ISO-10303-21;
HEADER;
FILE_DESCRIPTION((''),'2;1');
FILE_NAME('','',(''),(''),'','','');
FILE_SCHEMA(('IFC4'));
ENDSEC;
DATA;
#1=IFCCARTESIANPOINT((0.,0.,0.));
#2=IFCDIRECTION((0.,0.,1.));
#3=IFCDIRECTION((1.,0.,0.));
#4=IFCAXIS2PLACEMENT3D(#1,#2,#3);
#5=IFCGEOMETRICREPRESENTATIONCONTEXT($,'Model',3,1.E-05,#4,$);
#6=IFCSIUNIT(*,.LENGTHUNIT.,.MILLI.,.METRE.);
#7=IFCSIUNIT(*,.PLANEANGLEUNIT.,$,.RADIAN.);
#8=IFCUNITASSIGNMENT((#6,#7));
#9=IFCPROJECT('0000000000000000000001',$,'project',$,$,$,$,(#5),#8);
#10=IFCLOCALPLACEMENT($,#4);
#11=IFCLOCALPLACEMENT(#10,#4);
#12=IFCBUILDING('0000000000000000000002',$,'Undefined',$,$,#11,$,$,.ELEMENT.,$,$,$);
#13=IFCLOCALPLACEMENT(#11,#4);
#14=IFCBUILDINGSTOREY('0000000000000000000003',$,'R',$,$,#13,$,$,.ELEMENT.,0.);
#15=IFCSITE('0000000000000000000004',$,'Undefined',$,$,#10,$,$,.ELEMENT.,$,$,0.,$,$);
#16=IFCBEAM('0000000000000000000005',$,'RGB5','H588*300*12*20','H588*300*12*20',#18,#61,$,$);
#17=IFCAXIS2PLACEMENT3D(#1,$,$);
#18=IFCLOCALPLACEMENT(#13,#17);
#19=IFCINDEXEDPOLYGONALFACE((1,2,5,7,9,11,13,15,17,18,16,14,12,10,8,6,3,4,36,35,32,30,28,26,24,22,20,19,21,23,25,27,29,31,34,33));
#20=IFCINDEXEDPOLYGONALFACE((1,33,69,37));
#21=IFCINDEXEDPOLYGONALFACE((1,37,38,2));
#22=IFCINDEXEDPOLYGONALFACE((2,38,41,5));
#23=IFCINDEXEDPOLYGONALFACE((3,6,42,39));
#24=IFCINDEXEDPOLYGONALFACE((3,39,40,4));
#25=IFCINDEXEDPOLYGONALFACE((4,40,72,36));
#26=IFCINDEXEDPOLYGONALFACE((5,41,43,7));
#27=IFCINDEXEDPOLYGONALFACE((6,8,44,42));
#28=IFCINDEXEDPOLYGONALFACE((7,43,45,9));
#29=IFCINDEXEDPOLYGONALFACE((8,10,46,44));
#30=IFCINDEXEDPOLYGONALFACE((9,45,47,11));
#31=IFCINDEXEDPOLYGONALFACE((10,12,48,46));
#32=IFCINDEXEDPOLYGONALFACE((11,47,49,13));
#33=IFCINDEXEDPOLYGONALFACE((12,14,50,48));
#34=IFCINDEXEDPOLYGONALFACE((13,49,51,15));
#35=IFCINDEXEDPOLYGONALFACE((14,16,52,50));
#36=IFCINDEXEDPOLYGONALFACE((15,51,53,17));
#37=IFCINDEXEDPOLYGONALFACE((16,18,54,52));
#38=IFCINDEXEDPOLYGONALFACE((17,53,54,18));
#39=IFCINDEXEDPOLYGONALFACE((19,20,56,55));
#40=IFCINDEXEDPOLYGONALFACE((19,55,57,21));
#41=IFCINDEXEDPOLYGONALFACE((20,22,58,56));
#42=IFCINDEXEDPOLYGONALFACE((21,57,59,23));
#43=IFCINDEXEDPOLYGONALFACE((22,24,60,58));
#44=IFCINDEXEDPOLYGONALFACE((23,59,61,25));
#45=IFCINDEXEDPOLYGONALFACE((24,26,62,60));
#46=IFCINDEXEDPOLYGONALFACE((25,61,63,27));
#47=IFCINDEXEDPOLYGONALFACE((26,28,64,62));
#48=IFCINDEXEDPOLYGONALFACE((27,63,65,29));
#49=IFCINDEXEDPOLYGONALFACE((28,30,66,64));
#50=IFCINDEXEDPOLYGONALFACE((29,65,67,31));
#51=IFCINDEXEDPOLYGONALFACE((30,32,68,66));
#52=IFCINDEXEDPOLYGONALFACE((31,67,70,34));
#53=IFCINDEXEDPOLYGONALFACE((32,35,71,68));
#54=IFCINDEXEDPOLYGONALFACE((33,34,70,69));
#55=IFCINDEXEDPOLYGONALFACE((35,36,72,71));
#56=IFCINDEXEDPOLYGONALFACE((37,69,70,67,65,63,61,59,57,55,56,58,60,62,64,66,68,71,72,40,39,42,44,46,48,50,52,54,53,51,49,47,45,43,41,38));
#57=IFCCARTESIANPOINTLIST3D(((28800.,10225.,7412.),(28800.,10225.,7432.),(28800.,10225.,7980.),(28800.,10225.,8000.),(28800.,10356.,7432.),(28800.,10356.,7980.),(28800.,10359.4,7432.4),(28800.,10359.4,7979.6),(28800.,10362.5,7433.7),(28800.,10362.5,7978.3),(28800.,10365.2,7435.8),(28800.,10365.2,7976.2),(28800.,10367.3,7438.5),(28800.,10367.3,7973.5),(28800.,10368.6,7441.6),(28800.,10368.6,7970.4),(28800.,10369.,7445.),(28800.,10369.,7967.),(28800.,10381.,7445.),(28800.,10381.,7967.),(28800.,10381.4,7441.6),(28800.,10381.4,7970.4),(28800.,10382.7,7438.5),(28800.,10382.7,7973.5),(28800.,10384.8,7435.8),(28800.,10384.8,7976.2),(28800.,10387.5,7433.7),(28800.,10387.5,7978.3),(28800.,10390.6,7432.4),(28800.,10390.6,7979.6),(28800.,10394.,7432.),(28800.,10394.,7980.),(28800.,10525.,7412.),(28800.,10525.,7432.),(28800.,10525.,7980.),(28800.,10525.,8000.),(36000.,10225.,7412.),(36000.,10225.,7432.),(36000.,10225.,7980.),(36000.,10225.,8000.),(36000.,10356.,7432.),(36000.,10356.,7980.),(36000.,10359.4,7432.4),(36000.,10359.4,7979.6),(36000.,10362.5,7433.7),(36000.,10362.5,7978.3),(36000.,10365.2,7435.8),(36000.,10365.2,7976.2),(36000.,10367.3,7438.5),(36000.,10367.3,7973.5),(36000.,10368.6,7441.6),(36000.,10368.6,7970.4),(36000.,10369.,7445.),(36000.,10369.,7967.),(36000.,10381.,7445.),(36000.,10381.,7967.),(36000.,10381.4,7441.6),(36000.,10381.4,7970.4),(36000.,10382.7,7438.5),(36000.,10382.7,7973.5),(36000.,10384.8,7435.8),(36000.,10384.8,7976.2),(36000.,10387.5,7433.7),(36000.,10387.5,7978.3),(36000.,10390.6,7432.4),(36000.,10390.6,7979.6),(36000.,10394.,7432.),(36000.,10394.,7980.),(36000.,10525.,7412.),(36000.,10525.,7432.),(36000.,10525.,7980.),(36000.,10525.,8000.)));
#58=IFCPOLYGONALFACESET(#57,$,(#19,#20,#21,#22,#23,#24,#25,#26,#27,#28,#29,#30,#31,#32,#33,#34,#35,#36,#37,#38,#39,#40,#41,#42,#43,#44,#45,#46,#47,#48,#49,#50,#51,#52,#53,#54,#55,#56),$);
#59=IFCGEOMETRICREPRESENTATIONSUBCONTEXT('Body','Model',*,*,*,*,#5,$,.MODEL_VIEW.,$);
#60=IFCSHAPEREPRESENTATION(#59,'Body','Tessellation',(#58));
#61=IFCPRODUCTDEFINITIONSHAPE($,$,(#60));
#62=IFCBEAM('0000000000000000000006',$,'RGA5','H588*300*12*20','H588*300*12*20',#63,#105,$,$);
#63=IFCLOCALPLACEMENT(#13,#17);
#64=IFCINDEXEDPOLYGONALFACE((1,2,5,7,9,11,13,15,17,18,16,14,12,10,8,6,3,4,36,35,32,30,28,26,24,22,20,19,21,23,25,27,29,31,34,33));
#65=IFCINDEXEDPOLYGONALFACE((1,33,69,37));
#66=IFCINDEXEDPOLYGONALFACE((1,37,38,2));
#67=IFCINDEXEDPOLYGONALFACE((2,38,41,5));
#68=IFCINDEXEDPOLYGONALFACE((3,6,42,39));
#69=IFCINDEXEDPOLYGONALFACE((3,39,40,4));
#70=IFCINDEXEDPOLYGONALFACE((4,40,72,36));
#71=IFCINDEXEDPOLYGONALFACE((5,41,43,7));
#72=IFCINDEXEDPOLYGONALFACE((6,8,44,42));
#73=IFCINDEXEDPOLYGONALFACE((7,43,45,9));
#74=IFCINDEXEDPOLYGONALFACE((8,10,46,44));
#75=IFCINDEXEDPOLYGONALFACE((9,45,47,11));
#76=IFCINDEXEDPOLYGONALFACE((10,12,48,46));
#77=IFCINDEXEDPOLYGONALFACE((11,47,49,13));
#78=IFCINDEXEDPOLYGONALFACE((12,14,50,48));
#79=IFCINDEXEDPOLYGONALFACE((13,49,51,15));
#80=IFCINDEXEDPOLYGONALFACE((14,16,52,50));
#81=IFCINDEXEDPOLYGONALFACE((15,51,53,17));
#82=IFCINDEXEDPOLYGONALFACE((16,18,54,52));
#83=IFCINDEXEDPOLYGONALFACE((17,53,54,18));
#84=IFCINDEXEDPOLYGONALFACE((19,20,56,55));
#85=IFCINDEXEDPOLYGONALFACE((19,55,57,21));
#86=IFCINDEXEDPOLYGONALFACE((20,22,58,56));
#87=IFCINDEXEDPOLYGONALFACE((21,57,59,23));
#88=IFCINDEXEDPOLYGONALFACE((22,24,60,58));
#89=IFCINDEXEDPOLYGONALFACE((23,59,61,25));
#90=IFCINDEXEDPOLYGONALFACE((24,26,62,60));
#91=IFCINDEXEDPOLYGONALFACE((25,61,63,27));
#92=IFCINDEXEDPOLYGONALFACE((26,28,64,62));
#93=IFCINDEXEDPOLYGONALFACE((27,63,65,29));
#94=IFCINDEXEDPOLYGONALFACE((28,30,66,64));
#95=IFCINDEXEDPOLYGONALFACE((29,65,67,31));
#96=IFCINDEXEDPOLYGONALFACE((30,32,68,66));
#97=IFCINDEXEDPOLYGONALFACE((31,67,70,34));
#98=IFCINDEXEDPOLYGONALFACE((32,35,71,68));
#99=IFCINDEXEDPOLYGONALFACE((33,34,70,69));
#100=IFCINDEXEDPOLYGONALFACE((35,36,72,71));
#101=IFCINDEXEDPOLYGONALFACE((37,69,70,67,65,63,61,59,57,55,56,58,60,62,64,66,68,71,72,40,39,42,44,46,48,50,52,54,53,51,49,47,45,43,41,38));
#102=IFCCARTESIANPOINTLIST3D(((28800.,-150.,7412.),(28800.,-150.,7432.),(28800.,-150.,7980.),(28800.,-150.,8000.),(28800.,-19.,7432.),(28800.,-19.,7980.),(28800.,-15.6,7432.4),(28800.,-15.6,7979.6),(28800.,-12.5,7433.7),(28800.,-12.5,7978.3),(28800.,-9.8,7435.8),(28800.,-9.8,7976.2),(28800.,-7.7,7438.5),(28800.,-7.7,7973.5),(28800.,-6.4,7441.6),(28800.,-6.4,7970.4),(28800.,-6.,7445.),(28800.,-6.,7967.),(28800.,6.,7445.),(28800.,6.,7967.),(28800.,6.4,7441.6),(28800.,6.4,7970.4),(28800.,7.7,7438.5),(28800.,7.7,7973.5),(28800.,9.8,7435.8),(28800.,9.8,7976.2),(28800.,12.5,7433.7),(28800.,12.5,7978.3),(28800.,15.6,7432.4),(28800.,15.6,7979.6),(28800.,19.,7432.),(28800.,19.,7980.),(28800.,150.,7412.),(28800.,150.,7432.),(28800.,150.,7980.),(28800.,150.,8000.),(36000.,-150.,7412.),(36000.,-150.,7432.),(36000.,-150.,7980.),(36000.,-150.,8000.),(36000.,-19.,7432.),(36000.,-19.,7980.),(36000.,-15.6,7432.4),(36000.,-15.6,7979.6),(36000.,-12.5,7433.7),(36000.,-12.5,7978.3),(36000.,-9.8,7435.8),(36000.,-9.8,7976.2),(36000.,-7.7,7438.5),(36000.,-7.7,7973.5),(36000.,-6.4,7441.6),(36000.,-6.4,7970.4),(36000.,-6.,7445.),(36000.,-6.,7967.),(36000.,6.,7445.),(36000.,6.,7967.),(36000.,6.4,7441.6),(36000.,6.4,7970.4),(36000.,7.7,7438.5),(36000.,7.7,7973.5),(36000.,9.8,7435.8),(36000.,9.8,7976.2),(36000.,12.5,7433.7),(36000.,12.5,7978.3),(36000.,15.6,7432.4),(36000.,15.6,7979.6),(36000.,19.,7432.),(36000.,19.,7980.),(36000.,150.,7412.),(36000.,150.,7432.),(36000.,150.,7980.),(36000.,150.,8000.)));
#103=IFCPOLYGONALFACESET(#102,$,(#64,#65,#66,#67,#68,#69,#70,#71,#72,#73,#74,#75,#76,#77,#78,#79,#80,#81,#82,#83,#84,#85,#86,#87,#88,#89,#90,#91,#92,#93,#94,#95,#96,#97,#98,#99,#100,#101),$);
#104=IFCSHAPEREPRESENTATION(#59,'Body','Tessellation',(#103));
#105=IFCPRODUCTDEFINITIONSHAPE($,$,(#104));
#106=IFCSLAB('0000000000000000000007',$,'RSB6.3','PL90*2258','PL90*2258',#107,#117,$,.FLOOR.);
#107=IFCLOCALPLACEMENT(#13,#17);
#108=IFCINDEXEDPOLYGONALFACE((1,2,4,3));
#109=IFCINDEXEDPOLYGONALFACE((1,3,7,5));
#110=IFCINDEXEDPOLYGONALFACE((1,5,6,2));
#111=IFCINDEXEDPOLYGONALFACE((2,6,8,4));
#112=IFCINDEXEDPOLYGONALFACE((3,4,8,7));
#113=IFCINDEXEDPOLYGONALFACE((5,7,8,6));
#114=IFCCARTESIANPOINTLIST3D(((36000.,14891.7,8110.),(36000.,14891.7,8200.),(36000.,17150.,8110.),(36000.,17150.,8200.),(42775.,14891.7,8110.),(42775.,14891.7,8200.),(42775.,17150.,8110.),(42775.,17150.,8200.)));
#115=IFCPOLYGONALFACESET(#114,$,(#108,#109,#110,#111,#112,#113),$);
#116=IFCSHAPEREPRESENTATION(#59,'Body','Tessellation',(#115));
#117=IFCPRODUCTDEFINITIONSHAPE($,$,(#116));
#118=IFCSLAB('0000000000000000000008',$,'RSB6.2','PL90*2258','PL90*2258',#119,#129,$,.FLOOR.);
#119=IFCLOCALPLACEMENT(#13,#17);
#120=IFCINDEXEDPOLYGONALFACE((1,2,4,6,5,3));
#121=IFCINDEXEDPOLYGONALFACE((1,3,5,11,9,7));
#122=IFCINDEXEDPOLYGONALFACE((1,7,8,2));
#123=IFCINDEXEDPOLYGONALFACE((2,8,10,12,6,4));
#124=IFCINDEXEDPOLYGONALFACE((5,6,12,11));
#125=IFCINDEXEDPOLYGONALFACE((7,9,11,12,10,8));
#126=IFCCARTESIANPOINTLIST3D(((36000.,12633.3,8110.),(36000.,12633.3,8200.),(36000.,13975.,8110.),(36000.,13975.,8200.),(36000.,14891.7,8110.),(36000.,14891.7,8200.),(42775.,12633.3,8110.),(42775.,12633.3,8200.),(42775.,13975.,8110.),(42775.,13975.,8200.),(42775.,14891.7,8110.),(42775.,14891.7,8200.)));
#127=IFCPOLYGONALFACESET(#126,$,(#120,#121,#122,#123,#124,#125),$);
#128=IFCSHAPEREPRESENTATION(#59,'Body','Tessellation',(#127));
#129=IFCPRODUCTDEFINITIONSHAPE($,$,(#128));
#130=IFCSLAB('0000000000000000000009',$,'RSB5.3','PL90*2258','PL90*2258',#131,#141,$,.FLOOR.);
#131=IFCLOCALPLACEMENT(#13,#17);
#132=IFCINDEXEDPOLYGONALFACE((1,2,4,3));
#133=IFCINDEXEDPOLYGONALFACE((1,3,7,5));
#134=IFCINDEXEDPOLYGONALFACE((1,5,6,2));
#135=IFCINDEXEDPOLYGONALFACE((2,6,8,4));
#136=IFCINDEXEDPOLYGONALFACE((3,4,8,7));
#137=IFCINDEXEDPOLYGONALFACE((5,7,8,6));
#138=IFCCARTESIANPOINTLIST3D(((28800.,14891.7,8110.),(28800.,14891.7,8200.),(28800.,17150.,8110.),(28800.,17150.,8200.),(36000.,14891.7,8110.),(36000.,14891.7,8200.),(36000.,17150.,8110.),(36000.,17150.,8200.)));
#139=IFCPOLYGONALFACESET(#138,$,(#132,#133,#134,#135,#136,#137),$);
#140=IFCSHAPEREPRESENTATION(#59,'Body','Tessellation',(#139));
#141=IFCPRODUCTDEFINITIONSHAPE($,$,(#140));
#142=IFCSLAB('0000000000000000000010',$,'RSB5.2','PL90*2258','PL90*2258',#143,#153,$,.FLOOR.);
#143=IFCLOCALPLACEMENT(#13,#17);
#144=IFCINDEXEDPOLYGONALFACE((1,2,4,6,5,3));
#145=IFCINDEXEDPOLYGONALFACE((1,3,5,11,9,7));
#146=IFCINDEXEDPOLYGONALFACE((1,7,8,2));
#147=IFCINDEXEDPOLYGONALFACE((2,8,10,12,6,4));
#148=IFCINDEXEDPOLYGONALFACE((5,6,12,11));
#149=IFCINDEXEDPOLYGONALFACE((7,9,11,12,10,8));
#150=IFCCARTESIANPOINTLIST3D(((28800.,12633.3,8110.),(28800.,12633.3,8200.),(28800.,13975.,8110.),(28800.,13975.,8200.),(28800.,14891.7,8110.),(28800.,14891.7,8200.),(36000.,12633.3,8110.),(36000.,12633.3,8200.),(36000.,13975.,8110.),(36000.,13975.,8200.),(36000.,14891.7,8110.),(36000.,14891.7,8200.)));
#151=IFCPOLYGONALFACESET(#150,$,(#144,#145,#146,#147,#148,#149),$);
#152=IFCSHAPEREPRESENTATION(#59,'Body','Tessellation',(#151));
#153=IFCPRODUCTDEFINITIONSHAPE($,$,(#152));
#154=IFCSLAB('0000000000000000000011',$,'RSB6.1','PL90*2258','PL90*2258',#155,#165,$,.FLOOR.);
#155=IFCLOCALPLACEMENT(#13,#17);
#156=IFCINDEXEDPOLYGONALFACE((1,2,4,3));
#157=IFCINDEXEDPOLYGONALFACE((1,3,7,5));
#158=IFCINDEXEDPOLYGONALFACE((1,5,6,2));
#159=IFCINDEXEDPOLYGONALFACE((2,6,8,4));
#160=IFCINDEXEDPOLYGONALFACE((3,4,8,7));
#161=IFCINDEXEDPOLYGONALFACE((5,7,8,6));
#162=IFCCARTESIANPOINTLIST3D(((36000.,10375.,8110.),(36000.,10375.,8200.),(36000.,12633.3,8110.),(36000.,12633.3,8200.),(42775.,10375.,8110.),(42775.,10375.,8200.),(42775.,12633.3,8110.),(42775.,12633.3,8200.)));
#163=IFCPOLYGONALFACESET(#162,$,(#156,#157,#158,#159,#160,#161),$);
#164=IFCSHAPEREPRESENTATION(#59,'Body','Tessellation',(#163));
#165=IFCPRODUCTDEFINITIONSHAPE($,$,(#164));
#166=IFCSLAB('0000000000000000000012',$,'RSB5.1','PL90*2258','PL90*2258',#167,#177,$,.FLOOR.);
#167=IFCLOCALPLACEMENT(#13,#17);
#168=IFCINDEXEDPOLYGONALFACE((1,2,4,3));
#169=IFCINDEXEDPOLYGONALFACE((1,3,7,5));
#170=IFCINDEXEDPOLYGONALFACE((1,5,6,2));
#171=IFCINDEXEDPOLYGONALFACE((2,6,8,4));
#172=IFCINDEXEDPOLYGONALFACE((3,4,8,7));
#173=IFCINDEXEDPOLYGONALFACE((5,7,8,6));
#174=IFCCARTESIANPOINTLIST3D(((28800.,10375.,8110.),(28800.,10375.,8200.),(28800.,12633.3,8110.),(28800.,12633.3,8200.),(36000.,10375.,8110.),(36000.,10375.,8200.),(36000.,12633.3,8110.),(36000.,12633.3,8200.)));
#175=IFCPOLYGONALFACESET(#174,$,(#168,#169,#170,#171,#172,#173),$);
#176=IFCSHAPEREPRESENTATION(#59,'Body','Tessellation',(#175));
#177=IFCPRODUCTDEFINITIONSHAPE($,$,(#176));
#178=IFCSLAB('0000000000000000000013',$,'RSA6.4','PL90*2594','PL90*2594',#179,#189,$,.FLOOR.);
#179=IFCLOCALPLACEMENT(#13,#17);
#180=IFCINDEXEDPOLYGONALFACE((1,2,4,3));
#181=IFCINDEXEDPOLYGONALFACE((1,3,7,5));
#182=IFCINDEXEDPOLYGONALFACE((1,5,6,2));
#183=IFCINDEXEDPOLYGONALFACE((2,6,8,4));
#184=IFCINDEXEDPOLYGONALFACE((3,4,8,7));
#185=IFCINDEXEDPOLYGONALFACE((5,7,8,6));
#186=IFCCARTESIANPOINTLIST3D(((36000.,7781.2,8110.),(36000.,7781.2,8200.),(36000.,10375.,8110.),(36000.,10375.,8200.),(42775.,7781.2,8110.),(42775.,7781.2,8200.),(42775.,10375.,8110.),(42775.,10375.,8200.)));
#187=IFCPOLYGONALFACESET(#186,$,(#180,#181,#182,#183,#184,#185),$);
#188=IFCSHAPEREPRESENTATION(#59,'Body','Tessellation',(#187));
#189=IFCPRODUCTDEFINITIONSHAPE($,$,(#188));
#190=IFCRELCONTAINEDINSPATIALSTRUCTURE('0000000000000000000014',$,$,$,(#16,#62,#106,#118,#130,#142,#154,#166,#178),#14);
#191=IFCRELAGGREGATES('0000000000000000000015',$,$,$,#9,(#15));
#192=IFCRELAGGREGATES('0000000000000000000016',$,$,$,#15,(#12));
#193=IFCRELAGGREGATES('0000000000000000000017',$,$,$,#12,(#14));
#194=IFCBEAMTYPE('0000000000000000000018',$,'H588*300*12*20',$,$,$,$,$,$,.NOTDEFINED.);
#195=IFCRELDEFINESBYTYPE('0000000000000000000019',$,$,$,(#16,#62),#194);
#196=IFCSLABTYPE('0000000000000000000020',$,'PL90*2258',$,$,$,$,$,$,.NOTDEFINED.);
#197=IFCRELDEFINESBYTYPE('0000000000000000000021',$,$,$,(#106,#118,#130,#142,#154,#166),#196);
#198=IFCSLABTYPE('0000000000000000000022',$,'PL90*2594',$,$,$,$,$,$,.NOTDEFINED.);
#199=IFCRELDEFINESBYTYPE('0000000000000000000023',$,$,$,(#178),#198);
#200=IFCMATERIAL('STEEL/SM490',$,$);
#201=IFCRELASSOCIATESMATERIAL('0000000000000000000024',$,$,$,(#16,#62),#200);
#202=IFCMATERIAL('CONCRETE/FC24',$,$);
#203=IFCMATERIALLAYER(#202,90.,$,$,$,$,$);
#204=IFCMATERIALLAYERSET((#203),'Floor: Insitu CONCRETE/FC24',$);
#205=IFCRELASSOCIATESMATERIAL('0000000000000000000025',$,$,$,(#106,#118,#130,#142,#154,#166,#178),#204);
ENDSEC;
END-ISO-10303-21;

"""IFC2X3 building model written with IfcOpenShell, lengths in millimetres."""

from ifc_helpers import new_model, si_unit, frame, origin_with_axes, origin_2d_with_axis, place, context, subcontext, project, spatial, polyline, i_section, outline, extrude, material, layer, layer_set, layer_usage, type_object, element, save


model = new_model("IFC2X3")

# Units and contexts
model_context = context("Model", 3, precision=1e-05, world=origin_with_axes())
body_context = subcontext(model_context, "Body", "Model", "MODEL_VIEW")
ifc_project = project(units=[si_unit("LENGTHUNIT", "METRE", prefix="MILLI"), si_unit("PLANEANGLEUNIT", "RADIAN")], contexts=[model_context])

# Site, building, storey
site_placement = place(None, origin_with_axes())
site = spatial("IfcSite", under=ifc_project, at=site_placement, Name="Undefined", CompositionType="ELEMENT", RefElevation=0.0)
building_placement = place(site_placement, origin_with_axes())
building = spatial("IfcBuilding", under=site, at=building_placement, Name="Undefined", CompositionType="ELEMENT")
storey_placement = place(building_placement, origin_with_axes())
storey = spatial("IfcBuildingStorey", under=building, at=storey_placement, Name="R", CompositionType="ELEMENT", Elevation=0.0)

# Beams
ifc_material_1 = material(Name="STEEL/SM490")
beam_type_1 = type_object("IfcBeamType", Name="H588*300*12*20", PredefinedType="NOTDEFINED")
for number, where, z_axis, x_axis, name in (
    (1, (28800.0, 10375.0, 7706.0), (0.0, 0.0, 1.0), (1.0, 0.0, 0.0), "RGB5"),
    (2, (28800.0, 0.0, 7706.0), (0.0, 0.0, 1.0), (1.0, 0.0, 0.0), "RGA5"),
):
    element("IfcBeam", number, at=place(storey_placement, frame(where, z_axis=z_axis, x_axis=x_axis)), inside=storey, type_object=beam_type_1, material=ifc_material_1, Name=name, Description="H588*300*12*20", ObjectType="H588*300*12*20", context=body_context, shape_type="SweptSolid", body=[
        extrude(i_section(OverallWidth=300.0, OverallDepth=588.0, WebThickness=12.0, FlangeThickness=20.0, FilletRadius=13.0, at=origin_2d_with_axis()), frame((7200.0, 0.0, 0.0), z_axis=(-1.0, 0.0, 0.0), x_axis=(0.0, -1.0, 0.0)), (0.0, 0.0, 1.0), 7200.0),
    ])

# Slabs
ifc_material_2 = material(Name="CONCRETE/FC24")
ifc_layer = layer(ifc_material_2, 90.0)
ifc_layer_set = layer_set([ifc_layer], Name="Floor: Insitu CONCRETE/FC24")
ifc_layer_usage_1 = layer_usage(ifc_layer_set, "AXIS3", "POSITIVE", -45.0)
slab_type_1 = type_object("IfcSlabType", Name="PL90*2258", PredefinedType="NOTDEFINED")
slab_1_placement = place(storey_placement, frame((36000.0, 14891.7, 8155.0), z_axis=(0.0, 0.0, 1.0), x_axis=(1.0, 0.0, 0.0)))
element("IfcSlab", 3, at=slab_1_placement, inside=storey, type_object=slab_type_1, material=ifc_layer_usage_1, Name="RSB6.3", Description="PL90*2258", ObjectType="PL90*2258", PredefinedType="FLOOR", context=body_context, shape_type="SweptSolid", body=[
    extrude(outline(polyline([(0.0, 0.0), (6775.0, 0.0), (6775.0, 2258.3), (0.0, 2258.3), (0.0, 0.0)])), frame((0.0, 0.0, -45.0), z_axis=(0.0, 0.0, 1.0), x_axis=(1.0, 0.0, 0.0)), (0.0, 0.0, 1.0), 90.0),
])
ifc_layer_usage_2 = layer_usage(ifc_layer_set, "AXIS3", "POSITIVE", -45.0)
slab_2_placement = place(storey_placement, frame((36000.0, 12633.3, 8155.0), z_axis=(0.0, 0.0, 1.0), x_axis=(1.0, 0.0, 0.0)))
element("IfcSlab", 4, at=slab_2_placement, inside=storey, type_object=slab_type_1, material=ifc_layer_usage_2, Name="RSB6.2", Description="PL90*2258", ObjectType="PL90*2258", PredefinedType="FLOOR", context=body_context, shape_type="SweptSolid", body=[
    extrude(outline(polyline([(0.0, 0.0), (6775.0, 0.0), (6775.0, 1341.7), (6775.0, 2258.4), (0.0, 2258.4), (0.0, 1341.7), (0.0, 0.0)])), frame((0.0, 0.0, -45.0), z_axis=(0.0, 0.0, 1.0), x_axis=(1.0, 0.0, 0.0)), (0.0, 0.0, 1.0), 90.0),
])
ifc_layer_usage_3 = layer_usage(ifc_layer_set, "AXIS3", "POSITIVE", -45.0)
slab_3_placement = place(storey_placement, frame((28800.0, 14891.7, 8155.0), z_axis=(0.0, 0.0, 1.0), x_axis=(1.0, 0.0, 0.0)))
element("IfcSlab", 5, at=slab_3_placement, inside=storey, type_object=slab_type_1, material=ifc_layer_usage_3, Name="RSB5.3", Description="PL90*2258", ObjectType="PL90*2258", PredefinedType="FLOOR", context=body_context, shape_type="SweptSolid", body=[
    extrude(outline(polyline([(0.0, 0.0), (7200.0, 0.0), (7200.0, 2258.3), (0.0, 2258.3), (0.0, 0.0)])), frame((0.0, 0.0, -45.0), z_axis=(0.0, 0.0, 1.0), x_axis=(1.0, 0.0, 0.0)), (0.0, 0.0, 1.0), 90.0),
])
ifc_layer_usage_4 = layer_usage(ifc_layer_set, "AXIS3", "POSITIVE", -45.0)
slab_4_placement = place(storey_placement, frame((28800.0, 12633.3, 8155.0), z_axis=(0.0, 0.0, 1.0), x_axis=(1.0, 0.0, 0.0)))
element("IfcSlab", 6, at=slab_4_placement, inside=storey, type_object=slab_type_1, material=ifc_layer_usage_4, Name="RSB5.2", Description="PL90*2258", ObjectType="PL90*2258", PredefinedType="FLOOR", context=body_context, shape_type="SweptSolid", body=[
    extrude(outline(polyline([(0.0, 0.0), (7200.0, 0.0), (7200.0, 1341.7), (7200.0, 2258.4), (0.0, 2258.4), (0.0, 1341.7), (0.0, 0.0)])), frame((0.0, 0.0, -45.0), z_axis=(0.0, 0.0, 1.0), x_axis=(1.0, 0.0, 0.0)), (0.0, 0.0, 1.0), 90.0),
])
ifc_layer_usage_5 = layer_usage(ifc_layer_set, "AXIS3", "POSITIVE", -45.0)
slab_5_placement = place(storey_placement, frame((36000.0, 10375.0, 8155.0), z_axis=(0.0, 0.0, 1.0), x_axis=(1.0, 0.0, 0.0)))
element("IfcSlab", 7, at=slab_5_placement, inside=storey, type_object=slab_type_1, material=ifc_layer_usage_5, Name="RSB6.1", Description="PL90*2258", ObjectType="PL90*2258", PredefinedType="FLOOR", context=body_context, shape_type="SweptSolid", body=[
    extrude(outline(polyline([(0.0, 0.0), (6775.0, 0.0), (6775.0, 2258.3), (0.0, 2258.3), (0.0, 0.0)])), frame((0.0, 0.0, -45.0), z_axis=(0.0, 0.0, 1.0), x_axis=(1.0, 0.0, 0.0)), (0.0, 0.0, 1.0), 90.0),
])
ifc_layer_usage_6 = layer_usage(ifc_layer_set, "AXIS3", "POSITIVE", -45.0)
slab_6_placement = place(storey_placement, frame((28800.0, 10375.0, 8155.0), z_axis=(0.0, 0.0, 1.0), x_axis=(1.0, 0.0, 0.0)))
element("IfcSlab", 8, at=slab_6_placement, inside=storey, type_object=slab_type_1, material=ifc_layer_usage_6, Name="RSB5.1", Description="PL90*2258", ObjectType="PL90*2258", PredefinedType="FLOOR", context=body_context, shape_type="SweptSolid", body=[
    extrude(outline(polyline([(0.0, 0.0), (7200.0, 0.0), (7200.0, 2258.3), (0.0, 2258.3), (0.0, 0.0)])), frame((0.0, 0.0, -45.0), z_axis=(0.0, 0.0, 1.0), x_axis=(1.0, 0.0, 0.0)), (0.0, 0.0, 1.0), 90.0),
])
ifc_layer_usage_7 = layer_usage(ifc_layer_set, "AXIS3", "POSITIVE", -45.0)
slab_type_2 = type_object("IfcSlabType", Name="PL90*2594", PredefinedType="NOTDEFINED")
slab_7_placement = place(storey_placement, frame((36000.0, 7781.2, 8155.0), z_axis=(0.0, 0.0, 1.0), x_axis=(1.0, 0.0, 0.0)))
element("IfcSlab", 9, at=slab_7_placement, inside=storey, type_object=slab_type_2, material=ifc_layer_usage_7, Name="RSA6.4", Description="PL90*2594", ObjectType="PL90*2594", PredefinedType="FLOOR", context=body_context, shape_type="SweptSolid", body=[
    extrude(outline(polyline([(0.0, 0.0), (6775.0, 0.0), (6775.0, 2593.8), (0.0, 2593.8), (0.0, 0.0)])), frame((0.0, 0.0, -45.0), z_axis=(0.0, 0.0, 1.0), x_axis=(1.0, 0.0, 0.0)), (0.0, 0.0, 1.0), 90.0),
])

save(model, "model.ifc")
